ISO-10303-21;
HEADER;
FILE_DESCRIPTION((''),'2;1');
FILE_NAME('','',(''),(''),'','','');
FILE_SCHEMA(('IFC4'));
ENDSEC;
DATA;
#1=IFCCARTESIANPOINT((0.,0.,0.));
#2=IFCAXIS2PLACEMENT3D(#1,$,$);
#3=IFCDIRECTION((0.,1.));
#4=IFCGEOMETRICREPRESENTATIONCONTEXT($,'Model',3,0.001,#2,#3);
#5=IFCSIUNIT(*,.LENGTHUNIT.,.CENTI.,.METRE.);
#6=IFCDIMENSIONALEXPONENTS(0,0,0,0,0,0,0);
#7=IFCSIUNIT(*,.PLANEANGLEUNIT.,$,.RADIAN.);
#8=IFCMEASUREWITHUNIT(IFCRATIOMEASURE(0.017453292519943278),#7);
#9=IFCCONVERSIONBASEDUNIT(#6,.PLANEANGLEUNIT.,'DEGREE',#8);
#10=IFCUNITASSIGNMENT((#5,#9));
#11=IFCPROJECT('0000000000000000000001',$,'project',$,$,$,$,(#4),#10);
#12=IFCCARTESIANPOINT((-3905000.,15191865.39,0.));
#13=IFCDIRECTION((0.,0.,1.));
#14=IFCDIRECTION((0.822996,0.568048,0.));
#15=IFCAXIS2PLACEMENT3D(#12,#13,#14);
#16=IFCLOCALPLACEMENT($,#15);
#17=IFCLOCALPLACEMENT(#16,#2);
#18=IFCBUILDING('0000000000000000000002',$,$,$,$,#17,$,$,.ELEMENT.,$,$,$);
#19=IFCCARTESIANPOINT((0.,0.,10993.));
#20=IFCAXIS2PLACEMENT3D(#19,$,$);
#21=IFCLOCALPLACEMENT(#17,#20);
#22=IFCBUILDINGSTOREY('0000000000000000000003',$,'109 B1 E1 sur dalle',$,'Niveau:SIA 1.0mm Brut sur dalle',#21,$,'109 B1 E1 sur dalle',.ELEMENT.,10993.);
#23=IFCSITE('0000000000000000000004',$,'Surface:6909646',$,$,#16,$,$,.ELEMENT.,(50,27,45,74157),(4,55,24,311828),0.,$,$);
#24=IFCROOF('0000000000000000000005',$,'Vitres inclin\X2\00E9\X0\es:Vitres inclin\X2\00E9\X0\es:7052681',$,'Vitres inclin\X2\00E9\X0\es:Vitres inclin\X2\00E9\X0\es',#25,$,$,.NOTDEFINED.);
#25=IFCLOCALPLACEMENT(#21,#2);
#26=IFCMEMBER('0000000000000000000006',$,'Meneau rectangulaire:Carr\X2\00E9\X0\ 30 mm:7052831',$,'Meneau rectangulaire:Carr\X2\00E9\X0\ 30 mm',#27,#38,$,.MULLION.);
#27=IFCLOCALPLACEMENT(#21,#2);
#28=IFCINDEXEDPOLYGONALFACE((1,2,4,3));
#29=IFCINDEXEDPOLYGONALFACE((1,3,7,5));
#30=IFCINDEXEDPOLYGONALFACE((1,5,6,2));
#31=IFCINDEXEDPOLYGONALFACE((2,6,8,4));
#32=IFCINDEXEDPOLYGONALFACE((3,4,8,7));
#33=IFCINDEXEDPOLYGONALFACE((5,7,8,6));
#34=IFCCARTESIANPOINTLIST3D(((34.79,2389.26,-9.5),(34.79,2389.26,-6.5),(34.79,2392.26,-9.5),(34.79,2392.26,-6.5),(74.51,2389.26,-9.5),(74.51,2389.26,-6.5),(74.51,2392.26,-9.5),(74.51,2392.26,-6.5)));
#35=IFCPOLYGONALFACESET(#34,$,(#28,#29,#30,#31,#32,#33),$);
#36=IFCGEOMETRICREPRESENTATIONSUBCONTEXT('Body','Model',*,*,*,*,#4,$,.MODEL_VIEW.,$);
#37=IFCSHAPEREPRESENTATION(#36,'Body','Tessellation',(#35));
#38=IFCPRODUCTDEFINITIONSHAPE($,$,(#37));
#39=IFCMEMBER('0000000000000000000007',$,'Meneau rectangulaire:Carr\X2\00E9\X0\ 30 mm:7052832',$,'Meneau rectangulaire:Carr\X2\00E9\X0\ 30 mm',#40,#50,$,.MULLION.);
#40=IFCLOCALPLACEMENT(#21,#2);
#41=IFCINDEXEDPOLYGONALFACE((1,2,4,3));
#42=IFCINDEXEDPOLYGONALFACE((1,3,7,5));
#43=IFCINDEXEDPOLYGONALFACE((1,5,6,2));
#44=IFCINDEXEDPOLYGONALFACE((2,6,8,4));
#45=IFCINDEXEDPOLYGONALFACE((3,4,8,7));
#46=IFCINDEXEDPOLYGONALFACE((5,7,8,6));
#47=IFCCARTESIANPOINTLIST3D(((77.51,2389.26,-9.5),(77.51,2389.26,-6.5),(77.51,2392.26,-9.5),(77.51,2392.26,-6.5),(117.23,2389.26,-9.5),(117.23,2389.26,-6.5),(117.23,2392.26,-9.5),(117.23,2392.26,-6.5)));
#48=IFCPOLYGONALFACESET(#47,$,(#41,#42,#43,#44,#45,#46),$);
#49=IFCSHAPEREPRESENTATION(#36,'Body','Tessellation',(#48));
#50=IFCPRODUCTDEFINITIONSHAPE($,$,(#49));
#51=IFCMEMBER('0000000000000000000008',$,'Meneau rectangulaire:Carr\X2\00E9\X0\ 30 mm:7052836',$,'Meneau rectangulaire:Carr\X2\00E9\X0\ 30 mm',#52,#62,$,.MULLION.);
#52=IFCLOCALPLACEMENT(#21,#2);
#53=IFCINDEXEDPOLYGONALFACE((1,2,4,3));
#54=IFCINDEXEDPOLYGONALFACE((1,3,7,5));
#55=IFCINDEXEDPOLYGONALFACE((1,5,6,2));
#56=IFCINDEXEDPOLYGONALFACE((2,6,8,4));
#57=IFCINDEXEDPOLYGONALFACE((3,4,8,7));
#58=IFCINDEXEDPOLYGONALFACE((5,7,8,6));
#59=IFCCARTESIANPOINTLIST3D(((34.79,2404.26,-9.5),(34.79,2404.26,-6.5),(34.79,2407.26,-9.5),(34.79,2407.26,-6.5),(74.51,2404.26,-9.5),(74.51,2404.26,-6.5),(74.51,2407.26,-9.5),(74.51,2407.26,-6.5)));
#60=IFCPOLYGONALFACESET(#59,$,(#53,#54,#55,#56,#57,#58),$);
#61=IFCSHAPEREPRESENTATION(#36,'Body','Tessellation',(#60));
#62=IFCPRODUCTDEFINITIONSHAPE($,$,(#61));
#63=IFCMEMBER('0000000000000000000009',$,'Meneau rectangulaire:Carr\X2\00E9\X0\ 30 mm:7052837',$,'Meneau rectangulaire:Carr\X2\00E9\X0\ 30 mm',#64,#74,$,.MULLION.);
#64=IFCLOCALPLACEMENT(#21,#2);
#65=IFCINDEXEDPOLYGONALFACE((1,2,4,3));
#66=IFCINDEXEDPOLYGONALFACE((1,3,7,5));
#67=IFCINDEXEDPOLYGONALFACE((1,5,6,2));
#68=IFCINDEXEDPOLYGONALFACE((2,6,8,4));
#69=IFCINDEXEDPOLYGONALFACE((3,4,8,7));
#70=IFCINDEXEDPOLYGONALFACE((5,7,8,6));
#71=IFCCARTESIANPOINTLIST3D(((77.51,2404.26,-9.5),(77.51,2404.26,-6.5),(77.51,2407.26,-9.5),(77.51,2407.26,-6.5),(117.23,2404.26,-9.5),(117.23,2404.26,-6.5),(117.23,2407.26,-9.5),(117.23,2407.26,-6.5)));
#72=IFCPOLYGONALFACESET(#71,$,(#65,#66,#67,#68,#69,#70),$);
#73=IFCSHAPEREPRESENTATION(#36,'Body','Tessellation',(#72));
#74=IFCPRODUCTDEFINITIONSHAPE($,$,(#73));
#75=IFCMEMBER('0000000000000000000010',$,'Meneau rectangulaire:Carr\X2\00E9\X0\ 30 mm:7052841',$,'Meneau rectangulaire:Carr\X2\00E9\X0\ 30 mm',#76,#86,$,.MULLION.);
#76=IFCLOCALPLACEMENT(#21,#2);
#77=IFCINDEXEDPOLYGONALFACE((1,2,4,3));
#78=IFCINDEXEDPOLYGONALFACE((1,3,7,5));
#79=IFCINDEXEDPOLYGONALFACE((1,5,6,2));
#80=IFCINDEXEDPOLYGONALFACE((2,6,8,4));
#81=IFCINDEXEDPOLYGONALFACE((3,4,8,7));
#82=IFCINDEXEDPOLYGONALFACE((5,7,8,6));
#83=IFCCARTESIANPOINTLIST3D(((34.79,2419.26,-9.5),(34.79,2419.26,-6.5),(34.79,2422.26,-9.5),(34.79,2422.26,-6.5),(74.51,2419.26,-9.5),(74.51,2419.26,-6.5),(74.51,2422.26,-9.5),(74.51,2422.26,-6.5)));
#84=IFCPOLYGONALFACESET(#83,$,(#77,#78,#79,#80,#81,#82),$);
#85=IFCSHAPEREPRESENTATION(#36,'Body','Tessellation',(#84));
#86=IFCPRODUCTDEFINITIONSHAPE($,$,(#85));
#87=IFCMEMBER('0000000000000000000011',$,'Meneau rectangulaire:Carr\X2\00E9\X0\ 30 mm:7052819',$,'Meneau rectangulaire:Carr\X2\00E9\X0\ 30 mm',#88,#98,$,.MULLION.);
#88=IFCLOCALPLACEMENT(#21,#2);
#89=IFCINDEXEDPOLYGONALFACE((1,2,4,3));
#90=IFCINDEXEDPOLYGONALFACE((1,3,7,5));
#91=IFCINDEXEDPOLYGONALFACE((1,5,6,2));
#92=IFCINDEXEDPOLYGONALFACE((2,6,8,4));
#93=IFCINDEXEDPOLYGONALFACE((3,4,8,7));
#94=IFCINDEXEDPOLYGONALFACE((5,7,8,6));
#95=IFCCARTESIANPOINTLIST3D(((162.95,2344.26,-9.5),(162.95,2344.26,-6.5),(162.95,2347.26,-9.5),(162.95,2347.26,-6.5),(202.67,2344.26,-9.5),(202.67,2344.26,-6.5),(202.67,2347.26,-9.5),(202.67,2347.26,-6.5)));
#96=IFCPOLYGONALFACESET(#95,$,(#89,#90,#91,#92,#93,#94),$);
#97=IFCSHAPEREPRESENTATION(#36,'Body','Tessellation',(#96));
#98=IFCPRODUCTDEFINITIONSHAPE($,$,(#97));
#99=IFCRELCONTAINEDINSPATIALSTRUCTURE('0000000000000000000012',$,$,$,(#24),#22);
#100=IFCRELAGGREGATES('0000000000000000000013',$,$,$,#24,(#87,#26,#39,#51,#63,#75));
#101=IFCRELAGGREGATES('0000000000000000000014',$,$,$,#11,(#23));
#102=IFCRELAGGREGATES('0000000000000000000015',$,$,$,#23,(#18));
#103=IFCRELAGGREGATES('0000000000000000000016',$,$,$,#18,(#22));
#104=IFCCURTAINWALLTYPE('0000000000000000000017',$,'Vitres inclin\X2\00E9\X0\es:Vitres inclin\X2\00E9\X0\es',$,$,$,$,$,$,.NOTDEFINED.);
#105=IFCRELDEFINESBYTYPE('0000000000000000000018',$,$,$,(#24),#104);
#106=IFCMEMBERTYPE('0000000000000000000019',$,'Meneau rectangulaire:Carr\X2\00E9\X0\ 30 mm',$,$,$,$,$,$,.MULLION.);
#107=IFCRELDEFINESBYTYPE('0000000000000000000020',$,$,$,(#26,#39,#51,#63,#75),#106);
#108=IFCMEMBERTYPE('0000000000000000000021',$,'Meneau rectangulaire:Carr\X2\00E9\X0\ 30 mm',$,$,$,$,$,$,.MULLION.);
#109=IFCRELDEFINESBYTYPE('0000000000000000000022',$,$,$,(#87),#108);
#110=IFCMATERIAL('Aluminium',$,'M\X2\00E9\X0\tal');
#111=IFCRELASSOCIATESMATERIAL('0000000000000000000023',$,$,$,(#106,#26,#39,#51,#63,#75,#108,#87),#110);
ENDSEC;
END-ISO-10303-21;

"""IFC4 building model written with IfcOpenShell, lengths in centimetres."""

from ifc_helpers import new_model, entity, si_unit, converted_unit, direction, frame, origin, place, context, subcontext, project, spatial, indexed_curve, outline, extrude, source, transform, mapped, material, type_object, type_shapes, element, aggregate, save


model = new_model("IFC4")

# Units and contexts
model_context = context("Model", 3, precision=0.001, world=origin(), true_north=direction((0.0, 1.0)))
body_context = subcontext(model_context, "Body", "Model", "MODEL_VIEW")
ifc_project = project(units=[si_unit("LENGTHUNIT", "METRE", prefix="CENTI"), converted_unit("PLANEANGLEUNIT", "DEGREE", entity("IfcRatioMeasure", 0.017453292519943278), si_unit("PLANEANGLEUNIT", "RADIAN"), dimensions=[0, 0, 0, 0, 0, 0, 0])], contexts=[model_context])

# Site, building, storey
site_placement = place(None, frame((-3905000.0, 15191865.39, 0.0), z_axis=(0.0, 0.0, 1.0), x_axis=(0.822996, 0.568048, 0.0)))
site = spatial("IfcSite", under=ifc_project, at=site_placement, Name="Surface:6909646", CompositionType="ELEMENT", RefLatitude=(50, 27, 45, 74157), RefLongitude=(4, 55, 24, 311828), RefElevation=0.0)
building_placement = place(site_placement, origin())
building = spatial("IfcBuilding", under=site, at=building_placement, CompositionType="ELEMENT")
storey_placement = place(building_placement, frame((0.0, 0.0, 10993.0)))
storey = spatial("IfcBuildingStorey", under=building, at=storey_placement, Name="109 B1 E1 sur dalle", ObjectType="Niveau:SIA 1.0mm Brut sur dalle", LongName="109 B1 E1 sur dalle", CompositionType="ELEMENT", Elevation=10993.0)

# Roof, members
curtain_wall_type = type_object("IfcCurtainWallType", Name="Vitres inclinées:Vitres inclinées", PredefinedType="NOTDEFINED")
roof_placement = place(storey_placement, frame((0.0, 0.0, -10993.0)))
roof = element("IfcRoof", 1, at=roof_placement, inside=storey, type_object=curtain_wall_type, Name="Vitres inclinées:Vitres inclinées:7052681", ObjectType="Vitres inclinées:Vitres inclinées", PredefinedType="NOTDEFINED")
ifc_material = material(Name="Aluminium", Category="Métal")
member_type_1 = type_object("IfcMemberType", Name="Meneau rectangulaire:Carré 30 mm", PredefinedType="MULLION", material=ifc_material)
shared_shape_1 = source(origin(), body_context, "Body", "SweptSolid", [
    extrude(outline(indexed_curve([(-1.5, -1.5), (1.5, -1.5), (1.5, 1.5), (-1.5, 1.5), (-1.5, -1.5)], self_intersect=False)), frame((0.0, 0.0, -39.72), z_axis=(0.0, 0.0, 1.0), x_axis=(0.0, -1.0, 0.0)), (0.0, 0.0, 1.0), 39.72),
])
type_shapes(member_type_1, [shared_shape_1])
member_1_placement = place(roof_placement, frame((34.79, 2390.76, 10985.0), z_axis=(-1.0, 0.0, 0.0), x_axis=(0.0, 1.0, 0.0)))
member_1 = element("IfcMember", 2, at=member_1_placement, type_object=member_type_1, material=ifc_material, Name="Meneau rectangulaire:Carré 30 mm:7052831", ObjectType="Meneau rectangulaire:Carré 30 mm", PredefinedType="MULLION", context=body_context, shape_type="MappedRepresentation", body=[
    mapped(shared_shape_1, transform((0.0, 0.0, 0.0), scale=1.0)),
])
member_2_placement = place(roof_placement, frame((77.51, 2390.76, 10985.0), z_axis=(-1.0, 0.0, 0.0), x_axis=(0.0, 1.0, 0.0)))
member_2 = element("IfcMember", 3, at=member_2_placement, type_object=member_type_1, material=ifc_material, Name="Meneau rectangulaire:Carré 30 mm:7052832", ObjectType="Meneau rectangulaire:Carré 30 mm", PredefinedType="MULLION", context=body_context, shape_type="MappedRepresentation", body=[
    mapped(shared_shape_1, transform((0.0, 0.0, 0.0), scale=1.0)),
])
member_3_placement = place(roof_placement, frame((34.79, 2405.76, 10985.0), z_axis=(-1.0, 0.0, 0.0), x_axis=(0.0, 1.0, 0.0)))
member_3 = element("IfcMember", 4, at=member_3_placement, type_object=member_type_1, material=ifc_material, Name="Meneau rectangulaire:Carré 30 mm:7052836", ObjectType="Meneau rectangulaire:Carré 30 mm", PredefinedType="MULLION", context=body_context, shape_type="MappedRepresentation", body=[
    mapped(shared_shape_1, transform((0.0, 0.0, 0.0), scale=1.0)),
])
member_4_placement = place(roof_placement, frame((77.51, 2405.76, 10985.0), z_axis=(-1.0, 0.0, 0.0), x_axis=(0.0, 1.0, 0.0)))
member_4 = element("IfcMember", 5, at=member_4_placement, type_object=member_type_1, material=ifc_material, Name="Meneau rectangulaire:Carré 30 mm:7052837", ObjectType="Meneau rectangulaire:Carré 30 mm", PredefinedType="MULLION", context=body_context, shape_type="MappedRepresentation", body=[
    mapped(shared_shape_1, transform((0.0, 0.0, 0.0), scale=1.0)),
])
member_5_placement = place(roof_placement, frame((34.79, 2420.76, 10985.0), z_axis=(-1.0, 0.0, 0.0), x_axis=(0.0, 1.0, 0.0)))
member_5 = element("IfcMember", 6, at=member_5_placement, type_object=member_type_1, material=ifc_material, Name="Meneau rectangulaire:Carré 30 mm:7052841", ObjectType="Meneau rectangulaire:Carré 30 mm", PredefinedType="MULLION", context=body_context, shape_type="MappedRepresentation", body=[
    mapped(shared_shape_1, transform((0.0, 0.0, 0.0), scale=1.0)),
])
member_type_2 = type_object("IfcMemberType", Name="Meneau rectangulaire:Carré 30 mm", PredefinedType="MULLION", material=ifc_material)
shared_shape_2 = source(origin(), body_context, "Body", "SweptSolid", [
    extrude(outline(indexed_curve([(-1.5, -1.5), (1.5, -1.5), (1.5, 1.5), (-1.5, 1.5), (-1.5, -1.5)], self_intersect=False)), frame((0.0, 0.0, -39.72), z_axis=(0.0, 0.0, 1.0), x_axis=(0.0, -1.0, 0.0)), (0.0, 0.0, 1.0), 39.72),
])
type_shapes(member_type_2, [shared_shape_2])
member_6_placement = place(roof_placement, frame((162.95, 2345.76, 10985.0), z_axis=(-1.0, 0.0, 0.0), x_axis=(0.0, 1.0, 0.0)))
member_6 = element("IfcMember", 7, at=member_6_placement, type_object=member_type_2, material=ifc_material, Name="Meneau rectangulaire:Carré 30 mm:7052819", ObjectType="Meneau rectangulaire:Carré 30 mm", PredefinedType="MULLION", context=body_context, shape_type="MappedRepresentation", body=[
    mapped(shared_shape_2, transform((0.0, 0.0, 0.0), scale=1.0)),
])
aggregate(roof, [member_6, member_1, member_2, member_3, member_4, member_5])

save(model, "model.ifc")
